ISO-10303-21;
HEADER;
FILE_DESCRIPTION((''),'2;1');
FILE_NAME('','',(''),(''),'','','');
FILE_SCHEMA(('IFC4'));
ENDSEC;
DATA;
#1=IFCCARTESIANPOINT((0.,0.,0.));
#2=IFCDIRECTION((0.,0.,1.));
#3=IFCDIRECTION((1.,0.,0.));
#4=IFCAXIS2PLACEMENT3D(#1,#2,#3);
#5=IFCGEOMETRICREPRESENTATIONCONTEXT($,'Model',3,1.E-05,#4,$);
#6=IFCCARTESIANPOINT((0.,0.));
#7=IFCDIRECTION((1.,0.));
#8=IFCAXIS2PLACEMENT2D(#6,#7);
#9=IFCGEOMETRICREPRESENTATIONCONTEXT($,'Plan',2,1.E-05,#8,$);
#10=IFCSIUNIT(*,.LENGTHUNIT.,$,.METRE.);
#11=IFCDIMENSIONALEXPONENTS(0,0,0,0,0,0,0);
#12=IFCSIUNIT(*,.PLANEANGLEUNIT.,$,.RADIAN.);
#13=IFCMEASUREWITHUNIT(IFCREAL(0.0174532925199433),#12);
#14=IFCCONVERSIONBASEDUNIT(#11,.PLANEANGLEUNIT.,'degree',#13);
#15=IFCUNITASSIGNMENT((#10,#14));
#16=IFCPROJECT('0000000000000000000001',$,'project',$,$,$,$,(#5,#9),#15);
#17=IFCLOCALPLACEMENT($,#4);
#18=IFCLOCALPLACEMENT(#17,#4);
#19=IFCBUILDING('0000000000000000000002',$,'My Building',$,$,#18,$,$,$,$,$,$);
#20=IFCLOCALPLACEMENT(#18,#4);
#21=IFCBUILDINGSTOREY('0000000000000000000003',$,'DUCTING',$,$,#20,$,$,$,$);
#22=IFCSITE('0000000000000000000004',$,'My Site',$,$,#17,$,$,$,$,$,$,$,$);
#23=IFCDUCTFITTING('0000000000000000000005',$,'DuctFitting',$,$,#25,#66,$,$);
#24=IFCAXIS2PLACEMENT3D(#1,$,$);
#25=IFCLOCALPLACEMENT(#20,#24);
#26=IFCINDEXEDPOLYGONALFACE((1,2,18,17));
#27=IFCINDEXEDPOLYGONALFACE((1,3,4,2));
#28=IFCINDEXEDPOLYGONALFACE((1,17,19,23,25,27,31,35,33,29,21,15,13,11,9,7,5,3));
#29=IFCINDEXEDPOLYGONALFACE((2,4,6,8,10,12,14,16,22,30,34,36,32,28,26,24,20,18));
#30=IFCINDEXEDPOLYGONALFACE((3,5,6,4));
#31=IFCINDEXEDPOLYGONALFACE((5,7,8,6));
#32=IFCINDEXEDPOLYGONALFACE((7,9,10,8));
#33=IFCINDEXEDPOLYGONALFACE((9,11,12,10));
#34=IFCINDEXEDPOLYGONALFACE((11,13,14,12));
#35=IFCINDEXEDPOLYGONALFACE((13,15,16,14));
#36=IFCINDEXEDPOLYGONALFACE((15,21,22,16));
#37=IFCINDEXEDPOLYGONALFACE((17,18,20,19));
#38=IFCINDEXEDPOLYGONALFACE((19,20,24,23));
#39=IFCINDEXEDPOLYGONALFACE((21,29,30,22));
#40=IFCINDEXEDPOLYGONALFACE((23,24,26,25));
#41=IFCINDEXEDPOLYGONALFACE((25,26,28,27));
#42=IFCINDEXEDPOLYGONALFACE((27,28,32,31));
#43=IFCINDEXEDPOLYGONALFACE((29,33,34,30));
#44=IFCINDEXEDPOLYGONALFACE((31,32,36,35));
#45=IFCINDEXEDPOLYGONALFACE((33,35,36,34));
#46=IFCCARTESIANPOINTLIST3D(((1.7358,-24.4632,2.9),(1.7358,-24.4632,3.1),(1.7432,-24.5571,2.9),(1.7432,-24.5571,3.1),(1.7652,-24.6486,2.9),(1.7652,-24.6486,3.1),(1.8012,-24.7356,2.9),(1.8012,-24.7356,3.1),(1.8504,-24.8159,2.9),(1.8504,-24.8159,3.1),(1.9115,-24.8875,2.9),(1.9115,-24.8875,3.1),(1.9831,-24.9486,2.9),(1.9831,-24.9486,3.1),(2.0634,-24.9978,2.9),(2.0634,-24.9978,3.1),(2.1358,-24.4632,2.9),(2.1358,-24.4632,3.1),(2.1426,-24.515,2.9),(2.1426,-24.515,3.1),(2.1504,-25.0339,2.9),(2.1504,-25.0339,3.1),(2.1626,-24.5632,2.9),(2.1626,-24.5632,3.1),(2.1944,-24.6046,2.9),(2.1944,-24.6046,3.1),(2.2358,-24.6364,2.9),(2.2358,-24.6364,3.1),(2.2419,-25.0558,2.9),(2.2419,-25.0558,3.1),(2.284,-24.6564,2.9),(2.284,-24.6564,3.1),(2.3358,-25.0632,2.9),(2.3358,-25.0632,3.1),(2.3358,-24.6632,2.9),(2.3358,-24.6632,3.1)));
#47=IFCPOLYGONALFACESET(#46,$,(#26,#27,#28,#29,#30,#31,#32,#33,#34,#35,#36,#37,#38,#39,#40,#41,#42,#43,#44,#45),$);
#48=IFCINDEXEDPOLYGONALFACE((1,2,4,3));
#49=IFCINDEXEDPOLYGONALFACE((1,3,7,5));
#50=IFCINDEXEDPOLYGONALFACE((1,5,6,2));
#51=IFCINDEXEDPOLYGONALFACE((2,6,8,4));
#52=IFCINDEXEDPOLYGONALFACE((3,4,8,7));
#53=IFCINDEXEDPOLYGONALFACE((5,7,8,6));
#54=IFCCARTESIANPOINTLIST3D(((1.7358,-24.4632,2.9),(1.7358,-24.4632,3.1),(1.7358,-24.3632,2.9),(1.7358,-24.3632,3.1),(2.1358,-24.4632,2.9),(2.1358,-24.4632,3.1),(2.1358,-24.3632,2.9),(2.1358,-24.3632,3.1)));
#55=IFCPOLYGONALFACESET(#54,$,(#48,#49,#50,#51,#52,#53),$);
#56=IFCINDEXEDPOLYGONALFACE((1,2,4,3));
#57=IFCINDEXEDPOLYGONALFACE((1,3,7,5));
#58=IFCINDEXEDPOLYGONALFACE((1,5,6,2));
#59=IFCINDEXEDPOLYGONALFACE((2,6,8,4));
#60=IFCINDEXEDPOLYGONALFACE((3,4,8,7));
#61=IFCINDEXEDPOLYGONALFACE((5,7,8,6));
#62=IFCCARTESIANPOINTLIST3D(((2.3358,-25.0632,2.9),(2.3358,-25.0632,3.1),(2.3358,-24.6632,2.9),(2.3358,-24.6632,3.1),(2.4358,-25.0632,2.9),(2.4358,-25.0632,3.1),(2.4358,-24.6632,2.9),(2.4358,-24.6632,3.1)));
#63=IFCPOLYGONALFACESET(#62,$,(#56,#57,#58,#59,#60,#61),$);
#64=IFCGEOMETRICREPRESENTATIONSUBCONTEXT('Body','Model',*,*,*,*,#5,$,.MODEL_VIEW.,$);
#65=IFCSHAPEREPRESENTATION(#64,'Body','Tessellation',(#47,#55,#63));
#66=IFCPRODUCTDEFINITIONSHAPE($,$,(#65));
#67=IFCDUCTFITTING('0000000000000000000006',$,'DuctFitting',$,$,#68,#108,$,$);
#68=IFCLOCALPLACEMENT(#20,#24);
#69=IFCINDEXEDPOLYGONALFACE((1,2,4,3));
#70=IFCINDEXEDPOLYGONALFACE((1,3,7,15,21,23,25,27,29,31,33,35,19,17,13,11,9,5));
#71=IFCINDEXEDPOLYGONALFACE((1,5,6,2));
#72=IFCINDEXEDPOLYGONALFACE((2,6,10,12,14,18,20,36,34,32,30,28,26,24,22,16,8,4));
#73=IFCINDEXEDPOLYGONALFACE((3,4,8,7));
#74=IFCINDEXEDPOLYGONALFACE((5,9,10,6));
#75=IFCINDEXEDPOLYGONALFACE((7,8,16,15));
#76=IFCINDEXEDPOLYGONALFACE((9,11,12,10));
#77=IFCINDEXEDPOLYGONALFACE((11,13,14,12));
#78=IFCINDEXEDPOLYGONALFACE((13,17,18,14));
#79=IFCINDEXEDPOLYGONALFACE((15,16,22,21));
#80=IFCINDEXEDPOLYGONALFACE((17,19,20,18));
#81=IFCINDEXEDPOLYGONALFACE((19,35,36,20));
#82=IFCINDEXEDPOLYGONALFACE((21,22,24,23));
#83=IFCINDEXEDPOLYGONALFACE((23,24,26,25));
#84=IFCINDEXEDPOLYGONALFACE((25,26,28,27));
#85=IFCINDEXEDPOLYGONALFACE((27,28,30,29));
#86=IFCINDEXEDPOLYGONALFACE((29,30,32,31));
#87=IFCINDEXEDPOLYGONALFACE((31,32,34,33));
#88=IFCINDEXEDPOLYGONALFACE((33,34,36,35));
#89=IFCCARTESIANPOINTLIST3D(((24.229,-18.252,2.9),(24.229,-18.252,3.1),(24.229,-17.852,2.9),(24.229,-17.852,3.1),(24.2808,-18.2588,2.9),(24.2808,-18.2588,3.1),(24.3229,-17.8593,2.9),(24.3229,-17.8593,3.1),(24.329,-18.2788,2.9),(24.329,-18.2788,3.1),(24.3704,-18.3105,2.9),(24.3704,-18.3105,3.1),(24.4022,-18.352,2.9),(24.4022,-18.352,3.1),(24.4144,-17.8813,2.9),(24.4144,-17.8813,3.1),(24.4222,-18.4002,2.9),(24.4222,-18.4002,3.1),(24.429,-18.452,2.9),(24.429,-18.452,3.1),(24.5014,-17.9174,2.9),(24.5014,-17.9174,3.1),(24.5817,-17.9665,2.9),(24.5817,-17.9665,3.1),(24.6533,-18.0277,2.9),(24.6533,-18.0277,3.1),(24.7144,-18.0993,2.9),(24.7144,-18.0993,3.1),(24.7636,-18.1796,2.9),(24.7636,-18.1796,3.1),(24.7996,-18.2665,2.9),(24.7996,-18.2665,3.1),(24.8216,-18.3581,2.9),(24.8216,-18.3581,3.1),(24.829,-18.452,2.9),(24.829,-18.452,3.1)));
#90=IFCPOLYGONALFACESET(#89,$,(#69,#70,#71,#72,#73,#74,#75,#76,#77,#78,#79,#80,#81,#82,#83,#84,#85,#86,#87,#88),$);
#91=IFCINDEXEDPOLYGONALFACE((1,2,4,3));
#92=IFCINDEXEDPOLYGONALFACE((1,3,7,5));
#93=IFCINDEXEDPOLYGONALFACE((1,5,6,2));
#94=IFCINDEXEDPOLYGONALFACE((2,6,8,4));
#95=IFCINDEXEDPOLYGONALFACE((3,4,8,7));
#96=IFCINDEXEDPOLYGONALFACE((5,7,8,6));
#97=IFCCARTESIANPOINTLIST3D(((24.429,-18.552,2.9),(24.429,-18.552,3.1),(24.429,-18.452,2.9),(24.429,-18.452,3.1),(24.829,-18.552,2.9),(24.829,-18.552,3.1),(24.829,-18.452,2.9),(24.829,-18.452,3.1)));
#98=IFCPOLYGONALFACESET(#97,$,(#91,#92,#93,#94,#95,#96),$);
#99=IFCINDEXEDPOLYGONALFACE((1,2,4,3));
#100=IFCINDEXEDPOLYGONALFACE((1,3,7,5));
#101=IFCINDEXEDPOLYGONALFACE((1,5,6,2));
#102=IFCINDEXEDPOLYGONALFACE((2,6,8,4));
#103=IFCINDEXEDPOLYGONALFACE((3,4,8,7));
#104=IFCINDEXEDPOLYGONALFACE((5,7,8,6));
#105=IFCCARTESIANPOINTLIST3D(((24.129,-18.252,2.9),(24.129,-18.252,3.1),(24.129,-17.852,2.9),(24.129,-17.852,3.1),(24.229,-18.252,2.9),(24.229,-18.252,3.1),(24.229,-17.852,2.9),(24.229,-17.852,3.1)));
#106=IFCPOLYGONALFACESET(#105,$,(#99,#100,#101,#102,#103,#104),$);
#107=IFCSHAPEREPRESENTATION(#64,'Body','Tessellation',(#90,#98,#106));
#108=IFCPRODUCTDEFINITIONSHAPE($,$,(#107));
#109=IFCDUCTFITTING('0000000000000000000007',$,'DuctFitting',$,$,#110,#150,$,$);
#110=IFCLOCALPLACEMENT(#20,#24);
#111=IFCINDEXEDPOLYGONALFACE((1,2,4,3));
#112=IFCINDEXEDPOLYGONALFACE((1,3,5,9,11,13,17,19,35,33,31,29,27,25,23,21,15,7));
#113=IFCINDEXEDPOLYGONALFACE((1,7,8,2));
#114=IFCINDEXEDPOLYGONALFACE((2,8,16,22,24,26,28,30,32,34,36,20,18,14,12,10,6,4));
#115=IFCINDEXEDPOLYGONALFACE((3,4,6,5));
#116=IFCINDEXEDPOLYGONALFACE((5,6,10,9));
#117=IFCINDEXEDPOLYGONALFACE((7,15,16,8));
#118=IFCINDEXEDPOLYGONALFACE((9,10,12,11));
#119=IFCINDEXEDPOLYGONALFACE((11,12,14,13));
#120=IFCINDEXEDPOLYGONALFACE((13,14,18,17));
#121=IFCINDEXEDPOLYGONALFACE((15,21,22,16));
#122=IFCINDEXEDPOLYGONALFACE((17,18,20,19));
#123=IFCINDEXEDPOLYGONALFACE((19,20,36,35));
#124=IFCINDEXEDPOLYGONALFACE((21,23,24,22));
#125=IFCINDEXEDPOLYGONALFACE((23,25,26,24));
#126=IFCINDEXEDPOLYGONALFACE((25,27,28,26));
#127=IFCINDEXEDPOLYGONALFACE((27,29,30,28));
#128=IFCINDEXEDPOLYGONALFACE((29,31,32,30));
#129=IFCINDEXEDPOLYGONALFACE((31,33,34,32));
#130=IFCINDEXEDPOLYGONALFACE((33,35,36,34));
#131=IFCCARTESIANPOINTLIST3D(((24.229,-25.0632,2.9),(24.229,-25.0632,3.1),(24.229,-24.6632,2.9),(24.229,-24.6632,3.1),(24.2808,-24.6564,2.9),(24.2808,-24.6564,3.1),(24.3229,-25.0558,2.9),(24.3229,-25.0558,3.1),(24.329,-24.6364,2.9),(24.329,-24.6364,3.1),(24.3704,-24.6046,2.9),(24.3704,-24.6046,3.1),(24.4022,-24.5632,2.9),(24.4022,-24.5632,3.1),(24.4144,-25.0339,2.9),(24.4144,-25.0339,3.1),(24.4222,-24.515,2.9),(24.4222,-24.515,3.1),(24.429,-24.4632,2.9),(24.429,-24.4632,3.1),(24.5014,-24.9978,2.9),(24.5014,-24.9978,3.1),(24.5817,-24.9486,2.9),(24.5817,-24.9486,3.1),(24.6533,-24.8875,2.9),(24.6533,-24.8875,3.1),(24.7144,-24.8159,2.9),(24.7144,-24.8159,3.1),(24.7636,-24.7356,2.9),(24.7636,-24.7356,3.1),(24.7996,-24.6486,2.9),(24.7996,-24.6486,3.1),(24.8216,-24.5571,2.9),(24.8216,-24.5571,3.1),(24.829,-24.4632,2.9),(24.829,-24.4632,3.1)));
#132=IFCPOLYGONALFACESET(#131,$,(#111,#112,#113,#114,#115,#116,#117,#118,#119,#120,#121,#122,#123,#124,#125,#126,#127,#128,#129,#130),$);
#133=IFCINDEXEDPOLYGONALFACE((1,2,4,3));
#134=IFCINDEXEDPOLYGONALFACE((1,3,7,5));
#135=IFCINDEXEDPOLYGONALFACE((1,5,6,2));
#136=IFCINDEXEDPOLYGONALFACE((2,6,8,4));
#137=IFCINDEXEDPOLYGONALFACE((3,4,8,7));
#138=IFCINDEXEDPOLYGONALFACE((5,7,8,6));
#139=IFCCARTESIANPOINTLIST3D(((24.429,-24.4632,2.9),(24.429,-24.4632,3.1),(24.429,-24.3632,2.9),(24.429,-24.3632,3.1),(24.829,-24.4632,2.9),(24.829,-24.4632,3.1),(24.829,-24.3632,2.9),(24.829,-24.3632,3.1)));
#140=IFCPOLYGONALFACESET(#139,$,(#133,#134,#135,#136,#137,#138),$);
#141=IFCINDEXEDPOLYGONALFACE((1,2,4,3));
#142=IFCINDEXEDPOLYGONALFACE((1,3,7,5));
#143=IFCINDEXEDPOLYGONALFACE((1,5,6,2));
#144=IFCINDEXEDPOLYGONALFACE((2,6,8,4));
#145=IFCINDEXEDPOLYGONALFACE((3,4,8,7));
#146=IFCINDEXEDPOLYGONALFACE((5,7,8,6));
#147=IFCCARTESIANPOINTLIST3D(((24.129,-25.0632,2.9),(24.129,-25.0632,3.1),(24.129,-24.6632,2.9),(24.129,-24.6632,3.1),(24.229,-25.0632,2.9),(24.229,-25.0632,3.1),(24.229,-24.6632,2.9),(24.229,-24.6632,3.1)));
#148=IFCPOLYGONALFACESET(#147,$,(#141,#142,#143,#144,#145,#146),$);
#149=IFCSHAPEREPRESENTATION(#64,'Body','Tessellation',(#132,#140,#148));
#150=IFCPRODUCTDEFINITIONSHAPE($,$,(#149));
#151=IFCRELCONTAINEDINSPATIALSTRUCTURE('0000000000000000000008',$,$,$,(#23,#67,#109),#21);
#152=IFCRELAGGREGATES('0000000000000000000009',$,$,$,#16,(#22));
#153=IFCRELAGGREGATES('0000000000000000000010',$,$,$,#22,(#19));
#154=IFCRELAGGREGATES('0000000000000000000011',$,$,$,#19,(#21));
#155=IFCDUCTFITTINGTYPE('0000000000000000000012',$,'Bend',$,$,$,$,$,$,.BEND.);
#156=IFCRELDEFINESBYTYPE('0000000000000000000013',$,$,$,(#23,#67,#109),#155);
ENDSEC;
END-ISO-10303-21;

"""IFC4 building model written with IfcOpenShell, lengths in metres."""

from ifc_helpers import new_model, entity, si_unit, converted_unit, frame, origin_with_axes, origin_2d_with_axis, place, context, subcontext, project, spatial, line, arc, indexed_curve, rectangle, outline, extrude, source, transform, mapped, type_object, type_shapes, element, save


model = new_model("IFC4")

# Units and contexts
model_context = context("Model", 3, precision=1e-05, world=origin_with_axes())
plan_context = context("Plan", 2, precision=1e-05, world=origin_2d_with_axis())
body_context = subcontext(model_context, "Body", "Model", "MODEL_VIEW")
ifc_project = project(units=[si_unit("LENGTHUNIT", "METRE"), converted_unit("PLANEANGLEUNIT", "degree", entity("IfcReal", 0.0174532925199433), si_unit("PLANEANGLEUNIT", "RADIAN"), dimensions=[0, 0, 0, 0, 0, 0, 0])], contexts=[model_context, plan_context])

# Site, building, storey
site_placement = place(None, origin_with_axes())
site = spatial("IfcSite", under=ifc_project, at=site_placement, Name="My Site")
building_placement = place(site_placement, origin_with_axes())
building = spatial("IfcBuilding", under=site, at=building_placement, Name="My Building")
storey_placement = place(building_placement, origin_with_axes())
storey = spatial("IfcBuildingStorey", under=building, at=storey_placement, Name="DUCTING")

# Duct fittings
duct_fitting_type = type_object("IfcDuctFittingType", Name="Bend", PredefinedType="BEND")
shared_shape = source(origin_with_axes(), body_context, "Body", "SweptSolid", [
    extrude(outline(indexed_curve([(-0.2, 0.0), (-0.2586, -0.1414), (-0.4, -0.2), (-0.4, -0.6), (0.0243, -0.4243), (0.2, 0.0)], segments=[arc(1, 2, 3), line(3, 4), arc(4, 5, 6), line(6, 1)])), frame((0.0, -0.1, -0.1), z_axis=(0.0, -1.0, 0.0), x_axis=(1.0, 0.0, 0.0)), (0.0, 0.0, -1.0), 0.2),
    extrude(rectangle(XDim=0.4, YDim=0.2), origin_with_axes(), (0.0, 0.0, -1.0), 0.1),
    extrude(rectangle(XDim=0.4, YDim=0.2), frame((-0.4, 0.0, -0.5), z_axis=(-1.0, 0.0, 0.0), x_axis=(0.0, 0.0, -1.0)), (0.0, 0.0, 1.0), 0.1),
])
type_shapes(duct_fitting_type, [shared_shape])
for number, where, z_axis, x_axis, name in (
    (1, (1.9358, -24.3632, 3.0), (0.0, 1.0, 0.0), (-1.0, 0.0, 0.0), "DuctFitting"),
    (2, (24.629, -18.552, 3.0), (0.0, -1.0, 0.0), (1.0, 0.0, 0.0), "DuctFitting"),
    (3, (24.629, -24.3632, 3.0), (0.0, 1.0, 0.0), (1.0, 0.0, 0.0), "DuctFitting"),
):
    element("IfcDuctFitting", number, at=place(storey_placement, frame(where, z_axis=z_axis, x_axis=x_axis)), inside=storey, type_object=duct_fitting_type, Name=name, context=body_context, shape_type="MappedRepresentation", body=[
        mapped(shared_shape, transform((0.0, 0.0, 0.0), x_axis=(1.0, 0.0, 0.0), y_axis=(0.0, 1.0, 0.0), z_axis=(0.0, 0.0, 1.0), scale=1.0)),
    ])

save(model, "model.ifc")
